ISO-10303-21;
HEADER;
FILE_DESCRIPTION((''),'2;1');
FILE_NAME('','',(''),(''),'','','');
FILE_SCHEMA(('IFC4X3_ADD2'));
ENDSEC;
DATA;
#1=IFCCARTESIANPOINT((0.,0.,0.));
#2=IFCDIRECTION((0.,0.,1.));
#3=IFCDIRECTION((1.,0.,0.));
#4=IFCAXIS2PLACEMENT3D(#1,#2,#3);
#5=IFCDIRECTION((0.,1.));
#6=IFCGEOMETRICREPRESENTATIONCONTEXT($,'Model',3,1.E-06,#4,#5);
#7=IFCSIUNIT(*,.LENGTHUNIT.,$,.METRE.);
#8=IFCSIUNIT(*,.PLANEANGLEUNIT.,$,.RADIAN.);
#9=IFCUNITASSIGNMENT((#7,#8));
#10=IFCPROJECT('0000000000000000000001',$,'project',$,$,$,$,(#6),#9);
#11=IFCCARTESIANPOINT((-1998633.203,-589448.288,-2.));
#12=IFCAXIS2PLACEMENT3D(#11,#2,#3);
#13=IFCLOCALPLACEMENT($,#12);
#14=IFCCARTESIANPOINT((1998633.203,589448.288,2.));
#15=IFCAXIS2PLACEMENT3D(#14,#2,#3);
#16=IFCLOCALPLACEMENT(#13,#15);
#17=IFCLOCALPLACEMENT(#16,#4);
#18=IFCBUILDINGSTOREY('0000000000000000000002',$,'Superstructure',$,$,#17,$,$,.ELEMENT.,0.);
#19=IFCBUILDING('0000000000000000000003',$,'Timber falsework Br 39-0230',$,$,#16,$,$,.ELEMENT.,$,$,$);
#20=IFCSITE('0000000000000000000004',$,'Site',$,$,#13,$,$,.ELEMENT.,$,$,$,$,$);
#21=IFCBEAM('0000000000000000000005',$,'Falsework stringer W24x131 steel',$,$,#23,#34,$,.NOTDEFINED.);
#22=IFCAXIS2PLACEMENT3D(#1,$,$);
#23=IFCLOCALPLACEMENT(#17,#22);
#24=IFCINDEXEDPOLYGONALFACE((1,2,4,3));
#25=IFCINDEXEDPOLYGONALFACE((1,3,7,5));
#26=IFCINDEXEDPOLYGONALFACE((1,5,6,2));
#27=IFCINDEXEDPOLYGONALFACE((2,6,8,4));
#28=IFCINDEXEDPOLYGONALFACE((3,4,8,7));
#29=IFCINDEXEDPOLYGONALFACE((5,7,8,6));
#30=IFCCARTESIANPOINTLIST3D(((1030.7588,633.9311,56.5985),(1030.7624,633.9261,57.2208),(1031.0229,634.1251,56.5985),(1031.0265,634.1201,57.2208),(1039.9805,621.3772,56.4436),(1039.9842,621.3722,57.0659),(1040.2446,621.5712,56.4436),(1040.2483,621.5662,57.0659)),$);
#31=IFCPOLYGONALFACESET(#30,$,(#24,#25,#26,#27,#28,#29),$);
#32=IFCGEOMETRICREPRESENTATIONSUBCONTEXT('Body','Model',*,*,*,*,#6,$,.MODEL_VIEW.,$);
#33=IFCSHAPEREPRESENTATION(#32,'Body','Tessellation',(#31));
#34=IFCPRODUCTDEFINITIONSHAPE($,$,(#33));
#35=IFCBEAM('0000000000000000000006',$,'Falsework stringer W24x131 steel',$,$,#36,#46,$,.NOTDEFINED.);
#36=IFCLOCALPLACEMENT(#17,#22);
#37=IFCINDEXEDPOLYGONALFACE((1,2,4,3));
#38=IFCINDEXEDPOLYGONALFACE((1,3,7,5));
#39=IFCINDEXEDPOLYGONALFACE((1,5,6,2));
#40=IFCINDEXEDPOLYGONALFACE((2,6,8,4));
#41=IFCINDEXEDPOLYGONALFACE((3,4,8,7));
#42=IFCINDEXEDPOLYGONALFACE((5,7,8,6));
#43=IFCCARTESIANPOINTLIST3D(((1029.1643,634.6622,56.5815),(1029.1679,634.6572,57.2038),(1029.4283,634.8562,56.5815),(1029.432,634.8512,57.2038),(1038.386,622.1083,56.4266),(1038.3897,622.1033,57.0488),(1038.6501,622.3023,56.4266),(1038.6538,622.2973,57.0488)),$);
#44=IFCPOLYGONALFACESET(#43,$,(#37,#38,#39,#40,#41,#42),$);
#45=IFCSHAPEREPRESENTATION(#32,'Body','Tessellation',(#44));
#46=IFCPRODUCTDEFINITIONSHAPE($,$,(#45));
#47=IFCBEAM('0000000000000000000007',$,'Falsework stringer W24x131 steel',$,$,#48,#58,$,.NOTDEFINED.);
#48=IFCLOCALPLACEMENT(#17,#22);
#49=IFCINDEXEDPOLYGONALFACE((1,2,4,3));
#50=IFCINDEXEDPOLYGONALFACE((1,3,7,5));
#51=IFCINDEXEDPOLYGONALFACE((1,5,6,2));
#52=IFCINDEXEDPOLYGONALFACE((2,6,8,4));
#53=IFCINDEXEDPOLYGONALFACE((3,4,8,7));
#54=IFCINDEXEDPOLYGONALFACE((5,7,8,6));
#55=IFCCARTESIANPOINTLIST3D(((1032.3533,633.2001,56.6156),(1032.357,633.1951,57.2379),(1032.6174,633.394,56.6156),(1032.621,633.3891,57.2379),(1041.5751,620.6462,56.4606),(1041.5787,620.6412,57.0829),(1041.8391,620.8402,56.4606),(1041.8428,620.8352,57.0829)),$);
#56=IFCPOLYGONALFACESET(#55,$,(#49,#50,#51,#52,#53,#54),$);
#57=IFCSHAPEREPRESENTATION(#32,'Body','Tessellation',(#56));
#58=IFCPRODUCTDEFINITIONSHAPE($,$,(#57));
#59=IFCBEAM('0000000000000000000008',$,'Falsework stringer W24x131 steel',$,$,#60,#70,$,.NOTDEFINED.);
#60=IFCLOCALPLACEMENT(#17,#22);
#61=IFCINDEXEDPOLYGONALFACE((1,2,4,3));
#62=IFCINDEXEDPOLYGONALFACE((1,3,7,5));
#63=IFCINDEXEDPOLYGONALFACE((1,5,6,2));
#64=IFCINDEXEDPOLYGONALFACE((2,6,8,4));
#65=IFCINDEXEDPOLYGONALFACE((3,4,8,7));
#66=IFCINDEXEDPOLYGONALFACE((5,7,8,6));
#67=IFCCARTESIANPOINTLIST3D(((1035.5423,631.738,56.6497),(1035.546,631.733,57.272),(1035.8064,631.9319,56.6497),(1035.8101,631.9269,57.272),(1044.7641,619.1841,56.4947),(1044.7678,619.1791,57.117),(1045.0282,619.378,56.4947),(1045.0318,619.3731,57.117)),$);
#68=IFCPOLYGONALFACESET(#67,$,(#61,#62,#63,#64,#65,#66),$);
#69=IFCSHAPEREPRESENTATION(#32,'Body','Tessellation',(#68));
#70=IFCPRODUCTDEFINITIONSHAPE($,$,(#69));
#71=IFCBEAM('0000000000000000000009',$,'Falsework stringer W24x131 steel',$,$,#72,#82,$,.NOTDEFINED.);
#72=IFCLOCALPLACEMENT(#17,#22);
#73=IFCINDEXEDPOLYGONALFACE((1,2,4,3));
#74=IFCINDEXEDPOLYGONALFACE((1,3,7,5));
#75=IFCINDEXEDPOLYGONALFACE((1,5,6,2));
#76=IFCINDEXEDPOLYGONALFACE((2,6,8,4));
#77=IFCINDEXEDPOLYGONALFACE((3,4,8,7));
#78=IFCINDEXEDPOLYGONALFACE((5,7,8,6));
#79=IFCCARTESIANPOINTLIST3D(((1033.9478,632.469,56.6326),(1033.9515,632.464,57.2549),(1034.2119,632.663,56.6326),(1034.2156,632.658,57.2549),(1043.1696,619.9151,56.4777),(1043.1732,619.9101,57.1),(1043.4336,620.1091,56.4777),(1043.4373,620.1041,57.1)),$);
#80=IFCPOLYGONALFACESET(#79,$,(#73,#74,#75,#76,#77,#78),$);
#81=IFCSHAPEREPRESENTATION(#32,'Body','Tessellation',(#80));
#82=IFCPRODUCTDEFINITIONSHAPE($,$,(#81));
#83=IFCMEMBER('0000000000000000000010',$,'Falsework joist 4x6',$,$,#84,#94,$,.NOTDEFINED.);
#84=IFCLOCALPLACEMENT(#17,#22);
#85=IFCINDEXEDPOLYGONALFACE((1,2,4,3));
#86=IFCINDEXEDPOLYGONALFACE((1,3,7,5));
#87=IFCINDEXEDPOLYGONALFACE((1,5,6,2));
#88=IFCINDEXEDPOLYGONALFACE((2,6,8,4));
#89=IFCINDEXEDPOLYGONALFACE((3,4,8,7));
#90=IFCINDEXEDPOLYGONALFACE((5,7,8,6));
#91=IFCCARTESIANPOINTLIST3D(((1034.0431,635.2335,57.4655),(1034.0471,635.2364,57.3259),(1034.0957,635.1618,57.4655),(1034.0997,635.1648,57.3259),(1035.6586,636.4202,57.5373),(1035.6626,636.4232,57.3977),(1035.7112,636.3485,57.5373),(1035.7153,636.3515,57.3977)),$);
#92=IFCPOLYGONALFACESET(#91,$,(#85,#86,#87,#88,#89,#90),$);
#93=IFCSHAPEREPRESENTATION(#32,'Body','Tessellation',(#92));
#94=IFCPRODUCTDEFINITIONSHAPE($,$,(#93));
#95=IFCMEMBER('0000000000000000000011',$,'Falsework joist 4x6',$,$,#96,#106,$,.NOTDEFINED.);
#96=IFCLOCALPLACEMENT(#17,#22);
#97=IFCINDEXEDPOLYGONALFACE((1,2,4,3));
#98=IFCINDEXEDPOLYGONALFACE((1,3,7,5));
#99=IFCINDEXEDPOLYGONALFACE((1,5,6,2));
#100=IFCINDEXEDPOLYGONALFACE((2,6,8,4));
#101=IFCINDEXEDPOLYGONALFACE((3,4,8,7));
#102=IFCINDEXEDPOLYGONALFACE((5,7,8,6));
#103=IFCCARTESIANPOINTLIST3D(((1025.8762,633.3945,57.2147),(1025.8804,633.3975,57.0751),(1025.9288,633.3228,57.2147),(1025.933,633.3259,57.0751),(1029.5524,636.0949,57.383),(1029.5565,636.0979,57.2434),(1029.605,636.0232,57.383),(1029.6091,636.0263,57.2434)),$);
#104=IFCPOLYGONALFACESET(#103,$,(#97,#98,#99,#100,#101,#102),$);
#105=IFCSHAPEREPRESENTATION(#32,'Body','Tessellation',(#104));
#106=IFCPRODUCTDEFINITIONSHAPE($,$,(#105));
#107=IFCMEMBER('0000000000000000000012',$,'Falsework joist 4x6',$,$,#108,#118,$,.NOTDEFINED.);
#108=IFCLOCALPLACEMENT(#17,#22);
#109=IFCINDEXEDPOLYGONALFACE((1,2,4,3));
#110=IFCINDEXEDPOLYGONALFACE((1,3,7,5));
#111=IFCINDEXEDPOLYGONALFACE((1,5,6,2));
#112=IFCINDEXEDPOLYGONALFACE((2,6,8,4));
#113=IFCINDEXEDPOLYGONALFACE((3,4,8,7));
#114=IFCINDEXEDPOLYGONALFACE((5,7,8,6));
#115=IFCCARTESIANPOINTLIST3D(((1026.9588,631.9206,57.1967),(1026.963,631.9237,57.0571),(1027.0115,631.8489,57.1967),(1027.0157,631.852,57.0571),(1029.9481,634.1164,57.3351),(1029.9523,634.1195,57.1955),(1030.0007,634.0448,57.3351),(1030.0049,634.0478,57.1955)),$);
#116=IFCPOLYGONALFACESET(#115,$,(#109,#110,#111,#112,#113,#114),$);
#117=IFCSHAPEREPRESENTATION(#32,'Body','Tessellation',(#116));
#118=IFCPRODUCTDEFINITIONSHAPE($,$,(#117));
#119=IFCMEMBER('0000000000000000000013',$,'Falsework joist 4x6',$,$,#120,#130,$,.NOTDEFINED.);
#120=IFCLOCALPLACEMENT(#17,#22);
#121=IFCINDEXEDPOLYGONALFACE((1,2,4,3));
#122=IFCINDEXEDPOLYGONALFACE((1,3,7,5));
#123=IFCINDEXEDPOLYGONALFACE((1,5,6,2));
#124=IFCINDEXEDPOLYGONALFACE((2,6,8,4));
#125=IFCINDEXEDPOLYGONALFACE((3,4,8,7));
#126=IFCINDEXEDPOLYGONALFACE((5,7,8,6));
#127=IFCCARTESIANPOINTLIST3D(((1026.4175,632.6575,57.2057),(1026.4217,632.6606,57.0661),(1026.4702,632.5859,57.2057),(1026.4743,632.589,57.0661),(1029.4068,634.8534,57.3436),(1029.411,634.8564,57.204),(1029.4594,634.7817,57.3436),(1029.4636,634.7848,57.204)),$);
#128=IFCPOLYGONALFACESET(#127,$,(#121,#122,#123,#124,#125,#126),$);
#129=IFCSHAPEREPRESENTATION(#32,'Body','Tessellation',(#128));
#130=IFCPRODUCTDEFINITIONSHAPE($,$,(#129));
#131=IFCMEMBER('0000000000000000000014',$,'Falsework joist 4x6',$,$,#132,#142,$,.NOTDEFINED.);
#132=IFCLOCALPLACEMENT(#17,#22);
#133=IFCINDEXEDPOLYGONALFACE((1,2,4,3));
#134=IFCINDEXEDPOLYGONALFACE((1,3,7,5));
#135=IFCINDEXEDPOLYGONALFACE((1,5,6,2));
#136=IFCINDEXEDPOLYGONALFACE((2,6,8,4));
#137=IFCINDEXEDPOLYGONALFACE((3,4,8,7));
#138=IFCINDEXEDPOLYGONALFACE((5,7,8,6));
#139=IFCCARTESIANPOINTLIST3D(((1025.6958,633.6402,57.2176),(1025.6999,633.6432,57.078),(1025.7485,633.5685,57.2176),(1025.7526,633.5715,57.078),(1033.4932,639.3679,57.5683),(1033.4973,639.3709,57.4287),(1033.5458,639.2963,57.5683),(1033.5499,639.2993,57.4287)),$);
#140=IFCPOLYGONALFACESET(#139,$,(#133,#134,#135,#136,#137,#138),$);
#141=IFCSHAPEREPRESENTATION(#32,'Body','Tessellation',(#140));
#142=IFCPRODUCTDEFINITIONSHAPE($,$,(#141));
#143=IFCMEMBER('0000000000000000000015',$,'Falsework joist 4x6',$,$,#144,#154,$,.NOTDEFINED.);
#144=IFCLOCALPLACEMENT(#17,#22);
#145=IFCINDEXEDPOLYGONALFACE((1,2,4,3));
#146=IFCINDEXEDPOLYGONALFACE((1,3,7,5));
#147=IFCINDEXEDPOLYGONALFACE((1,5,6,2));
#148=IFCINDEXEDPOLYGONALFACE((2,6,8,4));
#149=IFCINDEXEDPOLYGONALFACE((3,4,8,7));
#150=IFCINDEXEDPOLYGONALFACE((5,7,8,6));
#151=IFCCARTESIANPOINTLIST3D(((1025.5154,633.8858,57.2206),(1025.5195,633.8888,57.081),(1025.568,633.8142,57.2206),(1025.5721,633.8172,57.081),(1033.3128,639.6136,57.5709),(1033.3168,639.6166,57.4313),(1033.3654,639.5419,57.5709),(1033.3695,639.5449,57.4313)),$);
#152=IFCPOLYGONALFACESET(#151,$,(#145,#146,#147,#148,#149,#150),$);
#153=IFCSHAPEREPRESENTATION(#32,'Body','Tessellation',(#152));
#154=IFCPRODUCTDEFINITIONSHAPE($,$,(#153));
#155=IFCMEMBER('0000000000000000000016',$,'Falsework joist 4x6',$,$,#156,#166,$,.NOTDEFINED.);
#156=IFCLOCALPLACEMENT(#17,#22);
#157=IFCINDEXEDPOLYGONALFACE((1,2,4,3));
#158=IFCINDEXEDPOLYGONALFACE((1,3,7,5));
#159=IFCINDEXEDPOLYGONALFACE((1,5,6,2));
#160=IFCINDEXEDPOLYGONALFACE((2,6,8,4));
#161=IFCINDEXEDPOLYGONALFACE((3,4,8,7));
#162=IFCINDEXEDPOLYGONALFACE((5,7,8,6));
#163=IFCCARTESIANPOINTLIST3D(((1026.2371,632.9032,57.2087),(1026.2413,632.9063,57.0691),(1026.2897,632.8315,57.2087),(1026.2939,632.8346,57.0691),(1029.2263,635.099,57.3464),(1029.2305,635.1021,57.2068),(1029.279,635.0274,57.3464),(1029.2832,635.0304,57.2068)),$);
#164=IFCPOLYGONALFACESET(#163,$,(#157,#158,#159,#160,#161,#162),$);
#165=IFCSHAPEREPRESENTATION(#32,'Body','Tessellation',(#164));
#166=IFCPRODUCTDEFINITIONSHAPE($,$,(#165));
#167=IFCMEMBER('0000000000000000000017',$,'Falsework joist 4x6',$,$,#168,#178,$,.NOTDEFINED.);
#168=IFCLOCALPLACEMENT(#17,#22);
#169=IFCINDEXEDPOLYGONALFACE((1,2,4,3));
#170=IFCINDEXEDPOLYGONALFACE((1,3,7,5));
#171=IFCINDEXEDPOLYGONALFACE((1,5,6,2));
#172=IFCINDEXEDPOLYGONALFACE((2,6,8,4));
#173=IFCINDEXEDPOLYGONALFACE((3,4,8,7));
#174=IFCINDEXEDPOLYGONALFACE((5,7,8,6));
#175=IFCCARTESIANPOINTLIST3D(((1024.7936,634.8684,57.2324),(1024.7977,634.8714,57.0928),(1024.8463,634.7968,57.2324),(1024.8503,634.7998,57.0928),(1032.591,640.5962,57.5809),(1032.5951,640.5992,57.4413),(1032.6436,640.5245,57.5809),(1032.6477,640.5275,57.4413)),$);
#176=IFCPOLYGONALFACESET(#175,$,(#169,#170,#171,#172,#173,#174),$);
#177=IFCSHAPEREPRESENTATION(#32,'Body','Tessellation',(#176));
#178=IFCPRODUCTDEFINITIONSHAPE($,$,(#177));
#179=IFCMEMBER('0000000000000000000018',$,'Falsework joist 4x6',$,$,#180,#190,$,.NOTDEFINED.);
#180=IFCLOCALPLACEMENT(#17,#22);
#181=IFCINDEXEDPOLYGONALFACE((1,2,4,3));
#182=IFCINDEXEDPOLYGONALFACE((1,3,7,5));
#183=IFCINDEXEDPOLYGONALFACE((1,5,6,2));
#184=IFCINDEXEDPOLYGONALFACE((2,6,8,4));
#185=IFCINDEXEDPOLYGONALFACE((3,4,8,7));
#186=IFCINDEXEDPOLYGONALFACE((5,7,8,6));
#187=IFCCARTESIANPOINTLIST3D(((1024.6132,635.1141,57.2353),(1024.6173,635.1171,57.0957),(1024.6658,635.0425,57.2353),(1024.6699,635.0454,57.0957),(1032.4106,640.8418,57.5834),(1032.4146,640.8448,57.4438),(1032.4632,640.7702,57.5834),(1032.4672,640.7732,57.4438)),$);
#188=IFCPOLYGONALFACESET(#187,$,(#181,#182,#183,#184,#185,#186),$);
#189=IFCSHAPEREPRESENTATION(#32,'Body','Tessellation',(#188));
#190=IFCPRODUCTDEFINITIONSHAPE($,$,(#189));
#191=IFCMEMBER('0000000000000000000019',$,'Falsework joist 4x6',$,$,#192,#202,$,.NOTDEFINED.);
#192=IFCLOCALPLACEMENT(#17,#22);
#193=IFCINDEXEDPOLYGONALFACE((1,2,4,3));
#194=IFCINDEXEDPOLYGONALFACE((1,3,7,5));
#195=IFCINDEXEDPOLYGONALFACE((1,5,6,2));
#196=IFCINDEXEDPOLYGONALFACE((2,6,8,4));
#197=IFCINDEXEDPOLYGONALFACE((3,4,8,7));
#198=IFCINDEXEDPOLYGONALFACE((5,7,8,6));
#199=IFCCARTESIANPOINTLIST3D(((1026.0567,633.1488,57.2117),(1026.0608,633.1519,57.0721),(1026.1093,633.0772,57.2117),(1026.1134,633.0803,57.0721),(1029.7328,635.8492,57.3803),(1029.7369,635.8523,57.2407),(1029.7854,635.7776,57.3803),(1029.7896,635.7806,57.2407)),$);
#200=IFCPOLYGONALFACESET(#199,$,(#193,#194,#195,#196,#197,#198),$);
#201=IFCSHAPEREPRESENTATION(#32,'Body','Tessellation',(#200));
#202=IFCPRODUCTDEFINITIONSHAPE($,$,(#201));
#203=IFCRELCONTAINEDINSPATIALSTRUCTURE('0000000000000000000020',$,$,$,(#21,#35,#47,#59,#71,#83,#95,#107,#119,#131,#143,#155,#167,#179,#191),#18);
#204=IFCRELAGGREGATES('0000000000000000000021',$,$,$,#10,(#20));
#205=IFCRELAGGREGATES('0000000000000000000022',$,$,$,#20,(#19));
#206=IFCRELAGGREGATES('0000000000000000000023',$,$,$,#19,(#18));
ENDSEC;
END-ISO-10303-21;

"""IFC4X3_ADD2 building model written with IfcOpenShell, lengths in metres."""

from ifc_helpers import new_model, si_unit, direction, frame, frame_2d, origin, origin_with_axes, place, context, subcontext, project, spatial, rectangle, extrude, element, save


model = new_model("IFC4X3_ADD2")

# Units and contexts
model_context = context("Model", 3, precision=1e-06, world=origin_with_axes(), true_north=direction((0.0, 1.0)))
body_context = subcontext(model_context, "Body", "Model", "MODEL_VIEW")
ifc_project = project(units=[si_unit("LENGTHUNIT", "METRE"), si_unit("PLANEANGLEUNIT", "RADIAN")], contexts=[model_context])

# Site, building, storey
site_placement = place(None, frame((-1998633.203, -589448.288, -2.0), z_axis=(0.0, 0.0, 1.0), x_axis=(1.0, 0.0, 0.0)))
site = spatial("IfcSite", under=ifc_project, at=site_placement, Name="Site", CompositionType="ELEMENT")
building_placement = place(site_placement, frame((1998633.203, 589448.288, 2.0), z_axis=(0.0, 0.0, 1.0), x_axis=(1.0, 0.0, 0.0)))
building = spatial("IfcBuilding", under=site, at=building_placement, Name="Timber falsework Br 39-0230", CompositionType="ELEMENT")
storey_placement = place(building_placement, origin_with_axes())
storey = spatial("IfcBuildingStorey", under=building, at=storey_placement, Name="Superstructure", CompositionType="ELEMENT", Elevation=0.0)

# Beams
beam_1_placement = place(storey_placement, frame((1030.8908, 634.0281, 56.5985), z_axis=(0.591984, -0.805888, -0.009947), x_axis=(0.805928, 0.592013, 0.0)))
element("IfcBeam", 1, at=beam_1_placement, inside=storey, Name="Falsework stringer W24x131 steel", PredefinedType="NOTDEFINED", context=body_context, shape_type="SweptSolid", body=[
    extrude(rectangle(XDim=0.3277, YDim=0.6223, at=frame_2d((0.0, 0.3111))), origin(), (0.0, 0.0, 1.0), 15.5777),
])
beam_2_placement = place(storey_placement, frame((1029.2963, 634.7592, 56.5815), z_axis=(0.591984, -0.805888, -0.009947), x_axis=(0.805928, 0.592013, 0.0)))
element("IfcBeam", 2, at=beam_2_placement, inside=storey, Name="Falsework stringer W24x131 steel", PredefinedType="NOTDEFINED", context=body_context, shape_type="SweptSolid", body=[
    extrude(rectangle(XDim=0.3277, YDim=0.6223, at=frame_2d((0.0, 0.3111))), origin(), (0.0, 0.0, 1.0), 15.5777),
])
beam_3_placement = place(storey_placement, frame((1032.4853, 633.2971, 56.6156), z_axis=(0.591984, -0.805888, -0.009947), x_axis=(0.805928, 0.592013, 0.0)))
element("IfcBeam", 3, at=beam_3_placement, inside=storey, Name="Falsework stringer W24x131 steel", PredefinedType="NOTDEFINED", context=body_context, shape_type="SweptSolid", body=[
    extrude(rectangle(XDim=0.3277, YDim=0.6223, at=frame_2d((0.0, 0.3111))), origin(), (0.0, 0.0, 1.0), 15.5777),
])
beam_4_placement = place(storey_placement, frame((1035.6744, 631.8349, 56.6497), z_axis=(0.591984, -0.805888, -0.009947), x_axis=(0.805928, 0.592013, 0.0)))
element("IfcBeam", 4, at=beam_4_placement, inside=storey, Name="Falsework stringer W24x131 steel", PredefinedType="NOTDEFINED", context=body_context, shape_type="SweptSolid", body=[
    extrude(rectangle(XDim=0.3277, YDim=0.6223, at=frame_2d((0.0, 0.3111))), origin(), (0.0, 0.0, 1.0), 15.5777),
])
beam_5_placement = place(storey_placement, frame((1034.0799, 632.566, 56.6326), z_axis=(0.591984, -0.805888, -0.009947), x_axis=(0.805928, 0.592013, 0.0)))
element("IfcBeam", 5, at=beam_5_placement, inside=storey, Name="Falsework stringer W24x131 steel", PredefinedType="NOTDEFINED", context=body_context, shape_type="SweptSolid", body=[
    extrude(rectangle(XDim=0.3277, YDim=0.6223, at=frame_2d((0.0, 0.3111))), origin(), (0.0, 0.0, 1.0), 15.5777),
])

# Members
member_1_placement = place(storey_placement, frame((1034.0734, 635.2006, 57.3259), z_axis=(0.805411, 0.591633, 0.03581), x_axis=(-0.592013, 0.805928, 0.0)))
element("IfcMember", 6, at=member_1_placement, inside=storey, Name="Falsework joist 4x6", PredefinedType="NOTDEFINED", context=body_context, shape_type="SweptSolid", body=[
    extrude(rectangle(XDim=0.0889, YDim=0.1397, at=frame_2d((0.0, 0.0698))), origin(), (0.0, 0.0, 1.0), 2.0058),
])
member_2_placement = place(storey_placement, frame((1025.9067, 633.3617, 57.0751), z_axis=(0.80538, 0.59161, 0.036887), x_axis=(-0.592013, 0.805928, 0.0)))
element("IfcMember", 7, at=member_2_placement, inside=storey, Name="Falsework joist 4x6", PredefinedType="NOTDEFINED", context=body_context, shape_type="SweptSolid", body=[
    extrude(rectangle(XDim=0.0889, YDim=0.1397, at=frame_2d((0.0, 0.0698))), origin(), (0.0, 0.0, 1.0), 4.5645),
])
member_3_placement = place(storey_placement, frame((1026.9894, 631.8878, 57.0571), z_axis=(0.805368, 0.591602, 0.037286), x_axis=(-0.592013, 0.805928, 0.0)))
element("IfcMember", 8, at=member_3_placement, inside=storey, Name="Falsework joist 4x6", PredefinedType="NOTDEFINED", context=body_context, shape_type="SweptSolid", body=[
    extrude(rectangle(XDim=0.0889, YDim=0.1397, at=frame_2d((0.0, 0.0698))), origin(), (0.0, 0.0, 1.0), 3.7117),
])
member_4_placement = place(storey_placement, frame((1026.448, 632.6248, 57.0661), z_axis=(0.805372, 0.591605, 0.037145), x_axis=(-0.592013, 0.805928, 0.0)))
element("IfcMember", 9, at=member_4_placement, inside=storey, Name="Falsework joist 4x6", PredefinedType="NOTDEFINED", context=body_context, shape_type="SweptSolid", body=[
    extrude(rectangle(XDim=0.0889, YDim=0.1397, at=frame_2d((0.0, 0.0698))), origin(), (0.0, 0.0, 1.0), 3.7117),
])
member_5_placement = place(storey_placement, frame((1025.7262, 633.6074, 57.078), z_axis=(0.805399, 0.591625, 0.036223), x_axis=(-0.592013, 0.805928, 0.0)))
element("IfcMember", 10, at=member_5_placement, inside=storey, Name="Falsework joist 4x6", PredefinedType="NOTDEFINED", context=body_context, shape_type="SweptSolid", body=[
    extrude(rectangle(XDim=0.0889, YDim=0.1397, at=frame_2d((0.0, 0.0698))), origin(), (0.0, 0.0, 1.0), 9.6814),
])
member_6_placement = place(storey_placement, frame((1025.5458, 633.853, 57.081), z_axis=(0.805401, 0.591626, 0.036179), x_axis=(-0.592013, 0.805928, 0.0)))
element("IfcMember", 11, at=member_6_placement, inside=storey, Name="Falsework joist 4x6", PredefinedType="NOTDEFINED", context=body_context, shape_type="SweptSolid", body=[
    extrude(rectangle(XDim=0.0889, YDim=0.1397, at=frame_2d((0.0, 0.0698))), origin(), (0.0, 0.0, 1.0), 9.6813),
])
member_7_placement = place(storey_placement, frame((1026.2676, 632.8704, 57.0691), z_axis=(0.805373, 0.591606, 0.037098), x_axis=(-0.592013, 0.805928, 0.0)))
element("IfcMember", 12, at=member_7_placement, inside=storey, Name="Falsework joist 4x6", PredefinedType="NOTDEFINED", context=body_context, shape_type="SweptSolid", body=[
    extrude(rectangle(XDim=0.0889, YDim=0.1397, at=frame_2d((0.0, 0.0698))), origin(), (0.0, 0.0, 1.0), 3.7116),
])
member_8_placement = place(storey_placement, frame((1024.824, 634.8356, 57.0928), z_axis=(0.805406, 0.591629, 0.036002), x_axis=(-0.592013, 0.805928, 0.0)))
element("IfcMember", 13, at=member_8_placement, inside=storey, Name="Falsework joist 4x6", PredefinedType="NOTDEFINED", context=body_context, shape_type="SweptSolid", body=[
    extrude(rectangle(XDim=0.0889, YDim=0.1397, at=frame_2d((0.0, 0.0698))), origin(), (0.0, 0.0, 1.0), 9.6813),
])
member_9_placement = place(storey_placement, frame((1024.6436, 635.0813, 57.0957), z_axis=(0.805407, 0.59163, 0.035957), x_axis=(-0.592013, 0.805928, 0.0)))
element("IfcMember", 14, at=member_9_placement, inside=storey, Name="Falsework joist 4x6", PredefinedType="NOTDEFINED", context=body_context, shape_type="SweptSolid", body=[
    extrude(rectangle(XDim=0.0889, YDim=0.1397, at=frame_2d((0.0, 0.0698))), origin(), (0.0, 0.0, 1.0), 9.6813),
])
member_10_placement = place(storey_placement, frame((1026.0871, 633.1161, 57.0721), z_axis=(0.805378, 0.591609, 0.036934), x_axis=(-0.592013, 0.805928, 0.0)))
element("IfcMember", 15, at=member_10_placement, inside=storey, Name="Falsework joist 4x6", PredefinedType="NOTDEFINED", context=body_context, shape_type="SweptSolid", body=[
    extrude(rectangle(XDim=0.0889, YDim=0.1397, at=frame_2d((0.0, 0.0698))), origin(), (0.0, 0.0, 1.0), 4.5645),
])

save(model, "model.ifc")
